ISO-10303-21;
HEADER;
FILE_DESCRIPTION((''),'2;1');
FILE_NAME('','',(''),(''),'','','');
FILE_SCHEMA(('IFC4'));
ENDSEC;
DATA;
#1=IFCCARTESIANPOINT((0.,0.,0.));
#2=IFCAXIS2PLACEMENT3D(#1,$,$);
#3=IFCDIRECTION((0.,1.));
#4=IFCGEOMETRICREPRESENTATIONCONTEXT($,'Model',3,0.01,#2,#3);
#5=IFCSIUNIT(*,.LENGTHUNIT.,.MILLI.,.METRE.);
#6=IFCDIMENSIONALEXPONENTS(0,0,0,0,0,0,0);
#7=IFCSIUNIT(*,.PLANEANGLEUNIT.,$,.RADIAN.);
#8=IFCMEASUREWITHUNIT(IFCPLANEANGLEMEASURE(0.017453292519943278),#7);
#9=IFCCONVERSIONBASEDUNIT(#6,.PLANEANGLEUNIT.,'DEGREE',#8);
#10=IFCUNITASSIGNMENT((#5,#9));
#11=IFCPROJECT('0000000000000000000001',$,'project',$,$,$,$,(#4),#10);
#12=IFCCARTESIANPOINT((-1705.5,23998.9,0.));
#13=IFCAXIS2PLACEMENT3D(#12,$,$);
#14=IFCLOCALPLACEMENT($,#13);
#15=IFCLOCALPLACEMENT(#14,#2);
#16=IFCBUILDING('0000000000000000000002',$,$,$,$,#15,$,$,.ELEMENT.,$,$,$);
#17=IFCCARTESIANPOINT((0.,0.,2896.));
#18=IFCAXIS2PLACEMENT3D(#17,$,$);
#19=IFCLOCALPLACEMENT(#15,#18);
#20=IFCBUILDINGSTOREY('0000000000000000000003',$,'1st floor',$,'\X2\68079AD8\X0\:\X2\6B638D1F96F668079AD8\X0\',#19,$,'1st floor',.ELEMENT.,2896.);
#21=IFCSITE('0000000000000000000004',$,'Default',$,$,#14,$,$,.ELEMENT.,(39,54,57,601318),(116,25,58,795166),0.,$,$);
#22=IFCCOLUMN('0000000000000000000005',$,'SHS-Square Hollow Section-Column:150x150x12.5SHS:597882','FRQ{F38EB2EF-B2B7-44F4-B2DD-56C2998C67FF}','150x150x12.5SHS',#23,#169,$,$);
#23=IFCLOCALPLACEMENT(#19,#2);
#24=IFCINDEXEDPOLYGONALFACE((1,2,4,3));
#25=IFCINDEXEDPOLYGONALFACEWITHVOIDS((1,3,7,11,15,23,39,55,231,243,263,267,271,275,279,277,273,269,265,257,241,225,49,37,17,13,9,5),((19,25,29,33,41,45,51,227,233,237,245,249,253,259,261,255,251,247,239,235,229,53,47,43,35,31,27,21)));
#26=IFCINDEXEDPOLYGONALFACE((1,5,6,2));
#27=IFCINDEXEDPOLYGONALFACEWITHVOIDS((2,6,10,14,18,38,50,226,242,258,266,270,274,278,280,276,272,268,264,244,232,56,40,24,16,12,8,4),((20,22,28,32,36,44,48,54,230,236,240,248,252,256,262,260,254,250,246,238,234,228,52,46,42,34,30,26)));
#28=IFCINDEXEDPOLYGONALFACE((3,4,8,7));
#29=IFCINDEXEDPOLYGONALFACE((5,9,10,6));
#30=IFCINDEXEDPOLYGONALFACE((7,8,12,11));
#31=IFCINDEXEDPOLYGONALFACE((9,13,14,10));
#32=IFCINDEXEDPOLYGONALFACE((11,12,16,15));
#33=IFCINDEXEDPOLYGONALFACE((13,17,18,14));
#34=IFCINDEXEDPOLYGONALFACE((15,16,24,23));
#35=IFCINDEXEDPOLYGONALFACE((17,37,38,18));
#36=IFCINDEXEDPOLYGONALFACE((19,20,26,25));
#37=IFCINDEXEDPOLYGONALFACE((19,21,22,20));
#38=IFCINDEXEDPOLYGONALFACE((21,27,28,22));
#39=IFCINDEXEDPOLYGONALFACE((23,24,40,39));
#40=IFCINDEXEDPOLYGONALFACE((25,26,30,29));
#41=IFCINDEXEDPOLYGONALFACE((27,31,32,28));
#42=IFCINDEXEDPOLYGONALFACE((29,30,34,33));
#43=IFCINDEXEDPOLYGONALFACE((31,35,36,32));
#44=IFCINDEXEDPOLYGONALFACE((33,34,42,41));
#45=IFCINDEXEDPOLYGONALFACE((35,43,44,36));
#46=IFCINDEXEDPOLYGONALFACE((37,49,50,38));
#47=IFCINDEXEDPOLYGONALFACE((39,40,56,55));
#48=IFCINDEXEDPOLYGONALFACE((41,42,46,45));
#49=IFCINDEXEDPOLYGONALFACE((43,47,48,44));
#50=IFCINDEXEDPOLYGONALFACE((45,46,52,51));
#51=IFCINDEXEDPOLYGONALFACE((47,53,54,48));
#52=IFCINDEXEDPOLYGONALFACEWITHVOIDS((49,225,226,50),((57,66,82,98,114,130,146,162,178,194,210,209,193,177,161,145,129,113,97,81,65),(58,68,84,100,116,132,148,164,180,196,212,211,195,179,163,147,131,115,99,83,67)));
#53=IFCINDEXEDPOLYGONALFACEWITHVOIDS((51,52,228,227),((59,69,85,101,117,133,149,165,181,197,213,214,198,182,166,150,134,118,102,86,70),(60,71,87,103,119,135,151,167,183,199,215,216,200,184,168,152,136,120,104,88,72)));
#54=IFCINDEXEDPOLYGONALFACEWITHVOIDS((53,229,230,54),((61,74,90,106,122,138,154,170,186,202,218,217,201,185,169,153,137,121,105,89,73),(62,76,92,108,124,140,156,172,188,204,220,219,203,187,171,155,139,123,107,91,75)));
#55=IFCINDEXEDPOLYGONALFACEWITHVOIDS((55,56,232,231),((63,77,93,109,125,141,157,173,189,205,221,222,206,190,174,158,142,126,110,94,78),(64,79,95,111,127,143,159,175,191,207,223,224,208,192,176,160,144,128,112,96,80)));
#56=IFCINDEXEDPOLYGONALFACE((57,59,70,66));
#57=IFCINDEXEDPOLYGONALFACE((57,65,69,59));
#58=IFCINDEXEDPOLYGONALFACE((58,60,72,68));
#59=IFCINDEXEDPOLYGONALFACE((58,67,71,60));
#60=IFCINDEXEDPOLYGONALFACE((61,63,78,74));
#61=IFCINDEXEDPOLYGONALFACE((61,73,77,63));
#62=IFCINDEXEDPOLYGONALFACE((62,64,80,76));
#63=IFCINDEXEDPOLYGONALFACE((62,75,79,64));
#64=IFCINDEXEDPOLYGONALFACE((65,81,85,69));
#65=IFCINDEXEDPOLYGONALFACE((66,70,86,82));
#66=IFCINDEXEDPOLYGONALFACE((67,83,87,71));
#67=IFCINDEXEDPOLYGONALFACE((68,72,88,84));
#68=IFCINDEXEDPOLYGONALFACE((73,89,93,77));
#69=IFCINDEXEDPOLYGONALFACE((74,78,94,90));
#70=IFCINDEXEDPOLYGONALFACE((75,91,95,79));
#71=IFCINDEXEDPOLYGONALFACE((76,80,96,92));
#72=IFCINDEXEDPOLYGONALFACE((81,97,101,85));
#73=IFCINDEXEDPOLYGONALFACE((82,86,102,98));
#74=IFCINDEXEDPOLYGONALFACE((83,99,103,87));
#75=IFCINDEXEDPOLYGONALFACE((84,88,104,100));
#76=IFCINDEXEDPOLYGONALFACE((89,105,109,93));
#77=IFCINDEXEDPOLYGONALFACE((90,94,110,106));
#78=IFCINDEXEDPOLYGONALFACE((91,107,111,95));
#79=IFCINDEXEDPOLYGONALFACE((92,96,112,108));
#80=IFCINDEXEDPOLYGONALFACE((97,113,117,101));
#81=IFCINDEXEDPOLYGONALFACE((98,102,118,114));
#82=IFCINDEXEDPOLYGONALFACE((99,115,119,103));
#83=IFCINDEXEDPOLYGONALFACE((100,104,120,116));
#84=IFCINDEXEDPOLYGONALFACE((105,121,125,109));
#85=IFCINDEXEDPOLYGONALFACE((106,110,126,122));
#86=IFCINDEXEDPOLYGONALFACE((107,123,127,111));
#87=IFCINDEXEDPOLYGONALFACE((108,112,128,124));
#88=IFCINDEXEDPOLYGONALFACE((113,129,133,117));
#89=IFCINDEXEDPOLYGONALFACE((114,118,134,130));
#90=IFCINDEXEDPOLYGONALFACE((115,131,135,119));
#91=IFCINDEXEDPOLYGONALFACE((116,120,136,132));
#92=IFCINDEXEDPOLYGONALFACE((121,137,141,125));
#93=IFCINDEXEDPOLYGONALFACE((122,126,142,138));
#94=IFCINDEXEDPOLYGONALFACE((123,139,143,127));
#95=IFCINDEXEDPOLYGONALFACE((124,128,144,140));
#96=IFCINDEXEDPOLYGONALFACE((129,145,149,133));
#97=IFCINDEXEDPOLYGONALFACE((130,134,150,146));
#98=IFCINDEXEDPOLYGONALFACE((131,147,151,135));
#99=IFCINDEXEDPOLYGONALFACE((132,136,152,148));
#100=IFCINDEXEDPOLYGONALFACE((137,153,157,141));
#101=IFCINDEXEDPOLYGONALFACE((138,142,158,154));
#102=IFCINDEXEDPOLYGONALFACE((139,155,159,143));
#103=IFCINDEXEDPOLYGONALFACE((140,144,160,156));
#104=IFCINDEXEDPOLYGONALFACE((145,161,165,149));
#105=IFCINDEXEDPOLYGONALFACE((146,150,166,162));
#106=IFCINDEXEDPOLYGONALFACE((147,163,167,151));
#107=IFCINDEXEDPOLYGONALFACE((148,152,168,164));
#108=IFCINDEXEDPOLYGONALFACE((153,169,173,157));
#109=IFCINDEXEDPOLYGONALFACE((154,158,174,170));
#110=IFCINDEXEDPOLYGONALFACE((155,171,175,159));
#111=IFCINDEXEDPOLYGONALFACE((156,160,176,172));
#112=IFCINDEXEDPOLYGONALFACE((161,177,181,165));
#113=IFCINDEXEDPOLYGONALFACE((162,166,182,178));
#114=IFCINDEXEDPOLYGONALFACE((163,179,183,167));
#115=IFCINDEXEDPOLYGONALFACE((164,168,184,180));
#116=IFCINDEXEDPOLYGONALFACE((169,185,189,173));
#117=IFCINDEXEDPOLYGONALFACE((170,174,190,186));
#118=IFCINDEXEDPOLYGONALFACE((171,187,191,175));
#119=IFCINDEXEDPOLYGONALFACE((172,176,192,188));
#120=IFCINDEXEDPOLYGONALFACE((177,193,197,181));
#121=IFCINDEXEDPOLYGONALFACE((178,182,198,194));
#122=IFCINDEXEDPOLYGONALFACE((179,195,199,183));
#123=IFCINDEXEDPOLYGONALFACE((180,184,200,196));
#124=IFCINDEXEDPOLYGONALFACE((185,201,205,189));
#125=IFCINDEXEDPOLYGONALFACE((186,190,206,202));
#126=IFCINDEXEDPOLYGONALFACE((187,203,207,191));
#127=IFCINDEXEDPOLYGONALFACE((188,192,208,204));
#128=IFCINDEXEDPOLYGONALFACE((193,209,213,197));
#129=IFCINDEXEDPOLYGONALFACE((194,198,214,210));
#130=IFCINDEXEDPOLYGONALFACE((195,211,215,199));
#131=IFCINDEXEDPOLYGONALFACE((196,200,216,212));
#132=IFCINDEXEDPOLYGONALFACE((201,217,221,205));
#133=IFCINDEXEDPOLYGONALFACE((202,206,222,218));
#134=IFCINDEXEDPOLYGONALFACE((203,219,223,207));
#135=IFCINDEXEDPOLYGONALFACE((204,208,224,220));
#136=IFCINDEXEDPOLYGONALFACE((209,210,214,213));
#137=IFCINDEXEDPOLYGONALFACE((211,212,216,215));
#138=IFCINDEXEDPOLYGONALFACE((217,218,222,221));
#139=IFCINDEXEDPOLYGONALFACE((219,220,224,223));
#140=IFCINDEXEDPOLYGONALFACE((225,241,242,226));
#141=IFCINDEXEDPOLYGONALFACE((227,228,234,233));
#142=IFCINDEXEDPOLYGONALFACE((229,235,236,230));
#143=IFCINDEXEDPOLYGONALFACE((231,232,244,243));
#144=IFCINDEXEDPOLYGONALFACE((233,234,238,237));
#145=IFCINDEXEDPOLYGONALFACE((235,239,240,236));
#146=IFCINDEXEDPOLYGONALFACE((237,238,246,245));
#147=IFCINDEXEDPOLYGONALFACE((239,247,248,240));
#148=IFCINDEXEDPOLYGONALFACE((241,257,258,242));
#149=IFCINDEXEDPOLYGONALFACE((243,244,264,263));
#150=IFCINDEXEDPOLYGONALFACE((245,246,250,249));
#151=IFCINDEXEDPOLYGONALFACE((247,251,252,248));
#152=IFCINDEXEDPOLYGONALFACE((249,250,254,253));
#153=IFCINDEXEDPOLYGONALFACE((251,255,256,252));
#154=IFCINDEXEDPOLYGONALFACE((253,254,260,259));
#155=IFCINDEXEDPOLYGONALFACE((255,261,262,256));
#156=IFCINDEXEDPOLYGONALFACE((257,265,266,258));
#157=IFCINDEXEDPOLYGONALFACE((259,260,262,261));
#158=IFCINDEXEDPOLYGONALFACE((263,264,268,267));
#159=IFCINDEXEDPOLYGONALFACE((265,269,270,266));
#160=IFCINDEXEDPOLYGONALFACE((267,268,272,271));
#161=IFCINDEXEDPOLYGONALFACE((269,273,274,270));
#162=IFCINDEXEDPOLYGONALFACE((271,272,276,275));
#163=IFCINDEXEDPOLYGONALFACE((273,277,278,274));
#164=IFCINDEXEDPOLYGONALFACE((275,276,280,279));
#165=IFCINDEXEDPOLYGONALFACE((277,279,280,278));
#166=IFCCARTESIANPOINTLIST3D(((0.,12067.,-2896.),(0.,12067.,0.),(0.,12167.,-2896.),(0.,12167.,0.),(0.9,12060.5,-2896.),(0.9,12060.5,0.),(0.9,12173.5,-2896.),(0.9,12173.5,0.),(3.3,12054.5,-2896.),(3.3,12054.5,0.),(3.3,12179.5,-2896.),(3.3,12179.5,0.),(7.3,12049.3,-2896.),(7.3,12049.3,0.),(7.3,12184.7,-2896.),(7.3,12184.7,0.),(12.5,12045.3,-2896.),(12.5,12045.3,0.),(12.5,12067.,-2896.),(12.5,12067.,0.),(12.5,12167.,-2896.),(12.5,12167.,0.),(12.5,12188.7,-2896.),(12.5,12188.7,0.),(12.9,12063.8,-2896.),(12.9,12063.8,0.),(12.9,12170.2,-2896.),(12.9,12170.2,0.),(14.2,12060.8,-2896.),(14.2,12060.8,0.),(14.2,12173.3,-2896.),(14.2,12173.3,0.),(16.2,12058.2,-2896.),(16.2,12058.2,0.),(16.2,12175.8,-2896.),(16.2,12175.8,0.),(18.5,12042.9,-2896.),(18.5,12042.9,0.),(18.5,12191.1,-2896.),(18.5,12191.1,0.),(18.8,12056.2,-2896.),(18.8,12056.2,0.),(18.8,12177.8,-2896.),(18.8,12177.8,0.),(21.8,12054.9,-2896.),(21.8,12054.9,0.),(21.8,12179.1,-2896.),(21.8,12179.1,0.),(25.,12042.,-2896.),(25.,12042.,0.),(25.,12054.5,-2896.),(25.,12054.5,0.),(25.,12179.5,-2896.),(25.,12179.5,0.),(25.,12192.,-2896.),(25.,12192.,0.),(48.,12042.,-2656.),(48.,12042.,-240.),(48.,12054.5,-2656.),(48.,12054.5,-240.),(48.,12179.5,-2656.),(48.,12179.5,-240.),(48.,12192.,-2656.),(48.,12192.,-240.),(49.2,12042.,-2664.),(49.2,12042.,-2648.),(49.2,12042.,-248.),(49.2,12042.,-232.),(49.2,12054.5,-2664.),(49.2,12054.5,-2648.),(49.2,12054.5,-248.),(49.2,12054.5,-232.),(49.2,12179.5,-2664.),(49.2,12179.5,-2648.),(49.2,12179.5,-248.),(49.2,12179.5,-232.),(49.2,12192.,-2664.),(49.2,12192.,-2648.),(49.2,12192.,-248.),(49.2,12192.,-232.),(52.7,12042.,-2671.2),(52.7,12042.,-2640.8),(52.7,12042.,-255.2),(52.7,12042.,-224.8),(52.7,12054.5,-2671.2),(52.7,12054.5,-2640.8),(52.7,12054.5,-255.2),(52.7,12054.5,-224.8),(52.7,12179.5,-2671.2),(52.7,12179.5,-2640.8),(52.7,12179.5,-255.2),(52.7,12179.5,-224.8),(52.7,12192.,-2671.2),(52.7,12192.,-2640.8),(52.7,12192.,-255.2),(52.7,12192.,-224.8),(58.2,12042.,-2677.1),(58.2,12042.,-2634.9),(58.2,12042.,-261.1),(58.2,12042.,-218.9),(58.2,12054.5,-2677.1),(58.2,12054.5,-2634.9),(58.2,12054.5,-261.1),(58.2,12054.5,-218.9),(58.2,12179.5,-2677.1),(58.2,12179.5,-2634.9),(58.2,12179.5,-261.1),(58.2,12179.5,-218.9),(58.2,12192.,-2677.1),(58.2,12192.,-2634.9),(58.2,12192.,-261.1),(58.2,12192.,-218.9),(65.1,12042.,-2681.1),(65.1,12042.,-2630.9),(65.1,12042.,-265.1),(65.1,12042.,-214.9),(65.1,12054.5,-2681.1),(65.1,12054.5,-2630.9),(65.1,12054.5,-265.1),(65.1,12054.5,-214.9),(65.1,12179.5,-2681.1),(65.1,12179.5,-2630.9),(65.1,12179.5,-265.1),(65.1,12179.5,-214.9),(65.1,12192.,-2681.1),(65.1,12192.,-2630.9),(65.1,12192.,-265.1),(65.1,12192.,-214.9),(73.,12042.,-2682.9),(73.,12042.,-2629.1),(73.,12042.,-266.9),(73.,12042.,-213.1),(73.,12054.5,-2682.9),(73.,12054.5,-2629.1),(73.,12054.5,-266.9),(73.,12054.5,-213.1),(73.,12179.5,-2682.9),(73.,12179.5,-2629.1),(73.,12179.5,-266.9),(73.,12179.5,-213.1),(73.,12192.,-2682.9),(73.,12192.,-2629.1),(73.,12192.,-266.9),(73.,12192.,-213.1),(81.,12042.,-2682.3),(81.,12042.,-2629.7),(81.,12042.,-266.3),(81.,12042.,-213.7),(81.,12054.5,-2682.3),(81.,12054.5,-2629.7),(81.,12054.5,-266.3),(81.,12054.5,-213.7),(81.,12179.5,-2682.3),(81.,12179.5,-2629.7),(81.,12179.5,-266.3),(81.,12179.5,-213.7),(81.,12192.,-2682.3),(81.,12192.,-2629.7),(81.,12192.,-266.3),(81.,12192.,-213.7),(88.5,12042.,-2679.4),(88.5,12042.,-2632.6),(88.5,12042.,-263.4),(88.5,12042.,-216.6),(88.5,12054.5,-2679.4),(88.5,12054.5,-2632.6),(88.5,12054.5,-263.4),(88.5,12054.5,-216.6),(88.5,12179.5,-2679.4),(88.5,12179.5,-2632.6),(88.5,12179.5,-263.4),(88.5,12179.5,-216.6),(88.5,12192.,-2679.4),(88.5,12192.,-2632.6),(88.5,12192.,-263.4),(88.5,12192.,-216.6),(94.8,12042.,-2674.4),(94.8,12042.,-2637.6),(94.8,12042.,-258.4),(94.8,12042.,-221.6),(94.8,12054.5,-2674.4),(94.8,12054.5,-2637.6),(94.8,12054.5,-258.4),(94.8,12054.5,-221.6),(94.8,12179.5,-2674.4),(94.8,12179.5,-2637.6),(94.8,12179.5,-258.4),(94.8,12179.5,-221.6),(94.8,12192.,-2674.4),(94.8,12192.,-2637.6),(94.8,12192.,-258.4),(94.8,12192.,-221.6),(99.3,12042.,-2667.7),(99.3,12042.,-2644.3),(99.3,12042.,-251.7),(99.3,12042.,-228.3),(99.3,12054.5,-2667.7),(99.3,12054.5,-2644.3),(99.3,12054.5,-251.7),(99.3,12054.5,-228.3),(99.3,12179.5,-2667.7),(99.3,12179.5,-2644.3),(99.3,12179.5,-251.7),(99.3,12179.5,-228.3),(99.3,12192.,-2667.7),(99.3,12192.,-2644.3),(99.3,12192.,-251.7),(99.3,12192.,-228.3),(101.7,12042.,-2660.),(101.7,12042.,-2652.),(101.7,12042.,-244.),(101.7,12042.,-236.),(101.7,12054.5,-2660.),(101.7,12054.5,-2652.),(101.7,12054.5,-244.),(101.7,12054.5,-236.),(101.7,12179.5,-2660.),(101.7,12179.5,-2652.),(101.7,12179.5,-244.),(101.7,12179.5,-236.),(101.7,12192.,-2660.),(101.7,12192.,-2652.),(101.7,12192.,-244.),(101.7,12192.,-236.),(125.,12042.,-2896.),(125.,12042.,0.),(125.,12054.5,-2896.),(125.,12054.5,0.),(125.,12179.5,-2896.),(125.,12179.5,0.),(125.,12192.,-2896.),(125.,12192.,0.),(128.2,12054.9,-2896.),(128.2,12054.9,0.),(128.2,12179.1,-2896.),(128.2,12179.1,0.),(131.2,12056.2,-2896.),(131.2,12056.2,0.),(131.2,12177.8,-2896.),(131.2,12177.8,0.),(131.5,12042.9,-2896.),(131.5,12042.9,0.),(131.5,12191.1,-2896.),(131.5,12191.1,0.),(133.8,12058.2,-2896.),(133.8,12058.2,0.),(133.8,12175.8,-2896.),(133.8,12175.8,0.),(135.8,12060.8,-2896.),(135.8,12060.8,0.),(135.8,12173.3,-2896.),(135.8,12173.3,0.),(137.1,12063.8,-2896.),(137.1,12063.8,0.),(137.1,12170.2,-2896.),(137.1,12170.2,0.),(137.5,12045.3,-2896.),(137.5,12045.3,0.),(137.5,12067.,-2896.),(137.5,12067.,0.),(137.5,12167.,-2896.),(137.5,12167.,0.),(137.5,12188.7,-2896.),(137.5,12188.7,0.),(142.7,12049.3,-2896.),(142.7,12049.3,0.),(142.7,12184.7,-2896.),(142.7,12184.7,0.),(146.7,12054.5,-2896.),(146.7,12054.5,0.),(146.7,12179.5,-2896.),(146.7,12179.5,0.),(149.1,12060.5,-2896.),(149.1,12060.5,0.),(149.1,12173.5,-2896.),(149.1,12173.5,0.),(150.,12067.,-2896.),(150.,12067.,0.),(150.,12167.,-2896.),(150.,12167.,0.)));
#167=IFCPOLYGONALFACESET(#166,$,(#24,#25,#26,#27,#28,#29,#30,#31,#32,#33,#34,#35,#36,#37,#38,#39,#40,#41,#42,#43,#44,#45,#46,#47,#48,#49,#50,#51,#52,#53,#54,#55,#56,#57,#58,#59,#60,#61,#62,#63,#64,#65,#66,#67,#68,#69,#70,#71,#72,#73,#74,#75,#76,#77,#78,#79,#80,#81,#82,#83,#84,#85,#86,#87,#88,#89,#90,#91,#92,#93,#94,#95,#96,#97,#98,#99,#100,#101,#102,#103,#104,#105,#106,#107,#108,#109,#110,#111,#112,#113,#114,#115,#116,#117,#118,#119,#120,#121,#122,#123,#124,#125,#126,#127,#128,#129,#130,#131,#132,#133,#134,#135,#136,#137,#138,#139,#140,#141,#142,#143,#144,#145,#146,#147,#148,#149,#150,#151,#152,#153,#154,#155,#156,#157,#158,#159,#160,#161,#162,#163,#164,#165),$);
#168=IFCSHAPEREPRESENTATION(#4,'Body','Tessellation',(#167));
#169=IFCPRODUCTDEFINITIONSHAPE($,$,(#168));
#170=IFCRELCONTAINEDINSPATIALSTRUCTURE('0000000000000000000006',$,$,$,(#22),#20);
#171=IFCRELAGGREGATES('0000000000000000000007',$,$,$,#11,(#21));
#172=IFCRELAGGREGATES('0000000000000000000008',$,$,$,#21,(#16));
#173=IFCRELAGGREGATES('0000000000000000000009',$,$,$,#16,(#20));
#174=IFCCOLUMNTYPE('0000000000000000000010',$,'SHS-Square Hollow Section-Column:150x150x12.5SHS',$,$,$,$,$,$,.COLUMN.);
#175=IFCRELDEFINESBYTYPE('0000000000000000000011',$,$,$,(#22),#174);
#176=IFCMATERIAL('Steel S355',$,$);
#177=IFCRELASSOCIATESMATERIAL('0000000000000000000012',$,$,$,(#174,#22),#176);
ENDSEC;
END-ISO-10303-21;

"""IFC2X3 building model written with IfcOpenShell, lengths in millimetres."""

from ifc_helpers import new_model, entity, si_unit, converted_unit, direction, frame, frame_2d, origin, origin_2d, place, context, project, spatial, circle_curve, hollow_rectangle, outline, extrude, material, type_object, element, save


model = new_model("IFC2X3")

# Units and contexts
model_context = context("Model", 3, precision=0.01, world=origin(), true_north=direction((0.0, 1.0)))
ifc_project = project(units=[si_unit("LENGTHUNIT", "METRE", prefix="MILLI"), converted_unit("PLANEANGLEUNIT", "DEGREE", entity("IfcPlaneAngleMeasure", 0.017453292519943278), si_unit("PLANEANGLEUNIT", "RADIAN"), dimensions=[0, 0, 0, 0, 0, 0, 0])], contexts=[model_context])

# Site, building, storey
site_placement = place(None, frame((-1705.5, 23998.9, 0.0)))
site = spatial("IfcSite", under=ifc_project, at=site_placement, Name="Default", CompositionType="ELEMENT", RefLatitude=(39, 54, 57, 601318), RefLongitude=(116, 25, 58, 795166), RefElevation=0.0)
building_placement = place(site_placement, origin())
building = spatial("IfcBuilding", under=site, at=building_placement, CompositionType="ELEMENT")
storey_placement = place(building_placement, frame((0.0, 0.0, 2896.0)))
storey = spatial("IfcBuildingStorey", under=building, at=storey_placement, Name="1st floor", ObjectType="标高:正负零标高", LongName="1st floor", CompositionType="ELEMENT", Elevation=2896.0)

# Column, openings
ifc_material_1 = material(Name="Steel S355")
column_type_1 = type_object("IfcColumnType", Name="SHS-Square Hollow Section-Column:150x150x12.5SHS", PredefinedType="COLUMN", material=ifc_material_1)
column_1_placement = place(storey_placement, frame((75.0, 12117.0, 0.0), z_axis=(0.0, 0.0, 1.0), x_axis=(0.0, -1.0, 0.0)))
column_1 = element("IfcColumn", 1, at=column_1_placement, inside=storey, type_object=column_type_1, material=ifc_material_1, Name="SHS-Square Hollow Section-Column:150x150x12.5SHS:597882", Description="FRQ{F38EB2EF-B2B7-44F4-B2DD-56C2998C67FF}", ObjectType="150x150x12.5SHS", context=model_context, shape_type="SweptSolid", body=[
    extrude(hollow_rectangle(XDim=150.0, YDim=150.0, WallThickness=12.5, InnerFilletRadius=12.5, OuterFilletRadius=25.0, at=origin_2d()), origin(), (0.0, 0.0, -1.0), 2896.0),
])
opening_1_placement = place(column_1_placement, frame((175.1, 0.0, -2896.0), z_axis=(-1.0, 0.0, 0.0), x_axis=(0.0, -1.0, 0.0)))
element("IfcOpeningElement", 2, at=opening_1_placement, cuts=column_1, ObjectType="Opening", context=model_context, shape_type="SweptSolid", body=[
    extrude(outline(circle_curve(frame_2d((0.0, 240.0), x_axis=(1.0, 0.0)), 27.0)), origin(), (0.0, 0.0, 1.0), 350.2),
])
opening_2_placement = place(column_1_placement, frame((175.1, 0.0, 0.0), z_axis=(-1.0, 0.0, 0.0), x_axis=(0.0, -1.0, 0.0)))
element("IfcOpeningElement", 3, at=opening_2_placement, cuts=column_1, ObjectType="Opening", context=model_context, shape_type="SweptSolid", body=[
    extrude(outline(circle_curve(frame_2d((0.0, -240.0), x_axis=(1.0, 0.0)), 27.0)), origin(), (0.0, 0.0, 1.0), 350.2),
])

save(model, "model.ifc")
